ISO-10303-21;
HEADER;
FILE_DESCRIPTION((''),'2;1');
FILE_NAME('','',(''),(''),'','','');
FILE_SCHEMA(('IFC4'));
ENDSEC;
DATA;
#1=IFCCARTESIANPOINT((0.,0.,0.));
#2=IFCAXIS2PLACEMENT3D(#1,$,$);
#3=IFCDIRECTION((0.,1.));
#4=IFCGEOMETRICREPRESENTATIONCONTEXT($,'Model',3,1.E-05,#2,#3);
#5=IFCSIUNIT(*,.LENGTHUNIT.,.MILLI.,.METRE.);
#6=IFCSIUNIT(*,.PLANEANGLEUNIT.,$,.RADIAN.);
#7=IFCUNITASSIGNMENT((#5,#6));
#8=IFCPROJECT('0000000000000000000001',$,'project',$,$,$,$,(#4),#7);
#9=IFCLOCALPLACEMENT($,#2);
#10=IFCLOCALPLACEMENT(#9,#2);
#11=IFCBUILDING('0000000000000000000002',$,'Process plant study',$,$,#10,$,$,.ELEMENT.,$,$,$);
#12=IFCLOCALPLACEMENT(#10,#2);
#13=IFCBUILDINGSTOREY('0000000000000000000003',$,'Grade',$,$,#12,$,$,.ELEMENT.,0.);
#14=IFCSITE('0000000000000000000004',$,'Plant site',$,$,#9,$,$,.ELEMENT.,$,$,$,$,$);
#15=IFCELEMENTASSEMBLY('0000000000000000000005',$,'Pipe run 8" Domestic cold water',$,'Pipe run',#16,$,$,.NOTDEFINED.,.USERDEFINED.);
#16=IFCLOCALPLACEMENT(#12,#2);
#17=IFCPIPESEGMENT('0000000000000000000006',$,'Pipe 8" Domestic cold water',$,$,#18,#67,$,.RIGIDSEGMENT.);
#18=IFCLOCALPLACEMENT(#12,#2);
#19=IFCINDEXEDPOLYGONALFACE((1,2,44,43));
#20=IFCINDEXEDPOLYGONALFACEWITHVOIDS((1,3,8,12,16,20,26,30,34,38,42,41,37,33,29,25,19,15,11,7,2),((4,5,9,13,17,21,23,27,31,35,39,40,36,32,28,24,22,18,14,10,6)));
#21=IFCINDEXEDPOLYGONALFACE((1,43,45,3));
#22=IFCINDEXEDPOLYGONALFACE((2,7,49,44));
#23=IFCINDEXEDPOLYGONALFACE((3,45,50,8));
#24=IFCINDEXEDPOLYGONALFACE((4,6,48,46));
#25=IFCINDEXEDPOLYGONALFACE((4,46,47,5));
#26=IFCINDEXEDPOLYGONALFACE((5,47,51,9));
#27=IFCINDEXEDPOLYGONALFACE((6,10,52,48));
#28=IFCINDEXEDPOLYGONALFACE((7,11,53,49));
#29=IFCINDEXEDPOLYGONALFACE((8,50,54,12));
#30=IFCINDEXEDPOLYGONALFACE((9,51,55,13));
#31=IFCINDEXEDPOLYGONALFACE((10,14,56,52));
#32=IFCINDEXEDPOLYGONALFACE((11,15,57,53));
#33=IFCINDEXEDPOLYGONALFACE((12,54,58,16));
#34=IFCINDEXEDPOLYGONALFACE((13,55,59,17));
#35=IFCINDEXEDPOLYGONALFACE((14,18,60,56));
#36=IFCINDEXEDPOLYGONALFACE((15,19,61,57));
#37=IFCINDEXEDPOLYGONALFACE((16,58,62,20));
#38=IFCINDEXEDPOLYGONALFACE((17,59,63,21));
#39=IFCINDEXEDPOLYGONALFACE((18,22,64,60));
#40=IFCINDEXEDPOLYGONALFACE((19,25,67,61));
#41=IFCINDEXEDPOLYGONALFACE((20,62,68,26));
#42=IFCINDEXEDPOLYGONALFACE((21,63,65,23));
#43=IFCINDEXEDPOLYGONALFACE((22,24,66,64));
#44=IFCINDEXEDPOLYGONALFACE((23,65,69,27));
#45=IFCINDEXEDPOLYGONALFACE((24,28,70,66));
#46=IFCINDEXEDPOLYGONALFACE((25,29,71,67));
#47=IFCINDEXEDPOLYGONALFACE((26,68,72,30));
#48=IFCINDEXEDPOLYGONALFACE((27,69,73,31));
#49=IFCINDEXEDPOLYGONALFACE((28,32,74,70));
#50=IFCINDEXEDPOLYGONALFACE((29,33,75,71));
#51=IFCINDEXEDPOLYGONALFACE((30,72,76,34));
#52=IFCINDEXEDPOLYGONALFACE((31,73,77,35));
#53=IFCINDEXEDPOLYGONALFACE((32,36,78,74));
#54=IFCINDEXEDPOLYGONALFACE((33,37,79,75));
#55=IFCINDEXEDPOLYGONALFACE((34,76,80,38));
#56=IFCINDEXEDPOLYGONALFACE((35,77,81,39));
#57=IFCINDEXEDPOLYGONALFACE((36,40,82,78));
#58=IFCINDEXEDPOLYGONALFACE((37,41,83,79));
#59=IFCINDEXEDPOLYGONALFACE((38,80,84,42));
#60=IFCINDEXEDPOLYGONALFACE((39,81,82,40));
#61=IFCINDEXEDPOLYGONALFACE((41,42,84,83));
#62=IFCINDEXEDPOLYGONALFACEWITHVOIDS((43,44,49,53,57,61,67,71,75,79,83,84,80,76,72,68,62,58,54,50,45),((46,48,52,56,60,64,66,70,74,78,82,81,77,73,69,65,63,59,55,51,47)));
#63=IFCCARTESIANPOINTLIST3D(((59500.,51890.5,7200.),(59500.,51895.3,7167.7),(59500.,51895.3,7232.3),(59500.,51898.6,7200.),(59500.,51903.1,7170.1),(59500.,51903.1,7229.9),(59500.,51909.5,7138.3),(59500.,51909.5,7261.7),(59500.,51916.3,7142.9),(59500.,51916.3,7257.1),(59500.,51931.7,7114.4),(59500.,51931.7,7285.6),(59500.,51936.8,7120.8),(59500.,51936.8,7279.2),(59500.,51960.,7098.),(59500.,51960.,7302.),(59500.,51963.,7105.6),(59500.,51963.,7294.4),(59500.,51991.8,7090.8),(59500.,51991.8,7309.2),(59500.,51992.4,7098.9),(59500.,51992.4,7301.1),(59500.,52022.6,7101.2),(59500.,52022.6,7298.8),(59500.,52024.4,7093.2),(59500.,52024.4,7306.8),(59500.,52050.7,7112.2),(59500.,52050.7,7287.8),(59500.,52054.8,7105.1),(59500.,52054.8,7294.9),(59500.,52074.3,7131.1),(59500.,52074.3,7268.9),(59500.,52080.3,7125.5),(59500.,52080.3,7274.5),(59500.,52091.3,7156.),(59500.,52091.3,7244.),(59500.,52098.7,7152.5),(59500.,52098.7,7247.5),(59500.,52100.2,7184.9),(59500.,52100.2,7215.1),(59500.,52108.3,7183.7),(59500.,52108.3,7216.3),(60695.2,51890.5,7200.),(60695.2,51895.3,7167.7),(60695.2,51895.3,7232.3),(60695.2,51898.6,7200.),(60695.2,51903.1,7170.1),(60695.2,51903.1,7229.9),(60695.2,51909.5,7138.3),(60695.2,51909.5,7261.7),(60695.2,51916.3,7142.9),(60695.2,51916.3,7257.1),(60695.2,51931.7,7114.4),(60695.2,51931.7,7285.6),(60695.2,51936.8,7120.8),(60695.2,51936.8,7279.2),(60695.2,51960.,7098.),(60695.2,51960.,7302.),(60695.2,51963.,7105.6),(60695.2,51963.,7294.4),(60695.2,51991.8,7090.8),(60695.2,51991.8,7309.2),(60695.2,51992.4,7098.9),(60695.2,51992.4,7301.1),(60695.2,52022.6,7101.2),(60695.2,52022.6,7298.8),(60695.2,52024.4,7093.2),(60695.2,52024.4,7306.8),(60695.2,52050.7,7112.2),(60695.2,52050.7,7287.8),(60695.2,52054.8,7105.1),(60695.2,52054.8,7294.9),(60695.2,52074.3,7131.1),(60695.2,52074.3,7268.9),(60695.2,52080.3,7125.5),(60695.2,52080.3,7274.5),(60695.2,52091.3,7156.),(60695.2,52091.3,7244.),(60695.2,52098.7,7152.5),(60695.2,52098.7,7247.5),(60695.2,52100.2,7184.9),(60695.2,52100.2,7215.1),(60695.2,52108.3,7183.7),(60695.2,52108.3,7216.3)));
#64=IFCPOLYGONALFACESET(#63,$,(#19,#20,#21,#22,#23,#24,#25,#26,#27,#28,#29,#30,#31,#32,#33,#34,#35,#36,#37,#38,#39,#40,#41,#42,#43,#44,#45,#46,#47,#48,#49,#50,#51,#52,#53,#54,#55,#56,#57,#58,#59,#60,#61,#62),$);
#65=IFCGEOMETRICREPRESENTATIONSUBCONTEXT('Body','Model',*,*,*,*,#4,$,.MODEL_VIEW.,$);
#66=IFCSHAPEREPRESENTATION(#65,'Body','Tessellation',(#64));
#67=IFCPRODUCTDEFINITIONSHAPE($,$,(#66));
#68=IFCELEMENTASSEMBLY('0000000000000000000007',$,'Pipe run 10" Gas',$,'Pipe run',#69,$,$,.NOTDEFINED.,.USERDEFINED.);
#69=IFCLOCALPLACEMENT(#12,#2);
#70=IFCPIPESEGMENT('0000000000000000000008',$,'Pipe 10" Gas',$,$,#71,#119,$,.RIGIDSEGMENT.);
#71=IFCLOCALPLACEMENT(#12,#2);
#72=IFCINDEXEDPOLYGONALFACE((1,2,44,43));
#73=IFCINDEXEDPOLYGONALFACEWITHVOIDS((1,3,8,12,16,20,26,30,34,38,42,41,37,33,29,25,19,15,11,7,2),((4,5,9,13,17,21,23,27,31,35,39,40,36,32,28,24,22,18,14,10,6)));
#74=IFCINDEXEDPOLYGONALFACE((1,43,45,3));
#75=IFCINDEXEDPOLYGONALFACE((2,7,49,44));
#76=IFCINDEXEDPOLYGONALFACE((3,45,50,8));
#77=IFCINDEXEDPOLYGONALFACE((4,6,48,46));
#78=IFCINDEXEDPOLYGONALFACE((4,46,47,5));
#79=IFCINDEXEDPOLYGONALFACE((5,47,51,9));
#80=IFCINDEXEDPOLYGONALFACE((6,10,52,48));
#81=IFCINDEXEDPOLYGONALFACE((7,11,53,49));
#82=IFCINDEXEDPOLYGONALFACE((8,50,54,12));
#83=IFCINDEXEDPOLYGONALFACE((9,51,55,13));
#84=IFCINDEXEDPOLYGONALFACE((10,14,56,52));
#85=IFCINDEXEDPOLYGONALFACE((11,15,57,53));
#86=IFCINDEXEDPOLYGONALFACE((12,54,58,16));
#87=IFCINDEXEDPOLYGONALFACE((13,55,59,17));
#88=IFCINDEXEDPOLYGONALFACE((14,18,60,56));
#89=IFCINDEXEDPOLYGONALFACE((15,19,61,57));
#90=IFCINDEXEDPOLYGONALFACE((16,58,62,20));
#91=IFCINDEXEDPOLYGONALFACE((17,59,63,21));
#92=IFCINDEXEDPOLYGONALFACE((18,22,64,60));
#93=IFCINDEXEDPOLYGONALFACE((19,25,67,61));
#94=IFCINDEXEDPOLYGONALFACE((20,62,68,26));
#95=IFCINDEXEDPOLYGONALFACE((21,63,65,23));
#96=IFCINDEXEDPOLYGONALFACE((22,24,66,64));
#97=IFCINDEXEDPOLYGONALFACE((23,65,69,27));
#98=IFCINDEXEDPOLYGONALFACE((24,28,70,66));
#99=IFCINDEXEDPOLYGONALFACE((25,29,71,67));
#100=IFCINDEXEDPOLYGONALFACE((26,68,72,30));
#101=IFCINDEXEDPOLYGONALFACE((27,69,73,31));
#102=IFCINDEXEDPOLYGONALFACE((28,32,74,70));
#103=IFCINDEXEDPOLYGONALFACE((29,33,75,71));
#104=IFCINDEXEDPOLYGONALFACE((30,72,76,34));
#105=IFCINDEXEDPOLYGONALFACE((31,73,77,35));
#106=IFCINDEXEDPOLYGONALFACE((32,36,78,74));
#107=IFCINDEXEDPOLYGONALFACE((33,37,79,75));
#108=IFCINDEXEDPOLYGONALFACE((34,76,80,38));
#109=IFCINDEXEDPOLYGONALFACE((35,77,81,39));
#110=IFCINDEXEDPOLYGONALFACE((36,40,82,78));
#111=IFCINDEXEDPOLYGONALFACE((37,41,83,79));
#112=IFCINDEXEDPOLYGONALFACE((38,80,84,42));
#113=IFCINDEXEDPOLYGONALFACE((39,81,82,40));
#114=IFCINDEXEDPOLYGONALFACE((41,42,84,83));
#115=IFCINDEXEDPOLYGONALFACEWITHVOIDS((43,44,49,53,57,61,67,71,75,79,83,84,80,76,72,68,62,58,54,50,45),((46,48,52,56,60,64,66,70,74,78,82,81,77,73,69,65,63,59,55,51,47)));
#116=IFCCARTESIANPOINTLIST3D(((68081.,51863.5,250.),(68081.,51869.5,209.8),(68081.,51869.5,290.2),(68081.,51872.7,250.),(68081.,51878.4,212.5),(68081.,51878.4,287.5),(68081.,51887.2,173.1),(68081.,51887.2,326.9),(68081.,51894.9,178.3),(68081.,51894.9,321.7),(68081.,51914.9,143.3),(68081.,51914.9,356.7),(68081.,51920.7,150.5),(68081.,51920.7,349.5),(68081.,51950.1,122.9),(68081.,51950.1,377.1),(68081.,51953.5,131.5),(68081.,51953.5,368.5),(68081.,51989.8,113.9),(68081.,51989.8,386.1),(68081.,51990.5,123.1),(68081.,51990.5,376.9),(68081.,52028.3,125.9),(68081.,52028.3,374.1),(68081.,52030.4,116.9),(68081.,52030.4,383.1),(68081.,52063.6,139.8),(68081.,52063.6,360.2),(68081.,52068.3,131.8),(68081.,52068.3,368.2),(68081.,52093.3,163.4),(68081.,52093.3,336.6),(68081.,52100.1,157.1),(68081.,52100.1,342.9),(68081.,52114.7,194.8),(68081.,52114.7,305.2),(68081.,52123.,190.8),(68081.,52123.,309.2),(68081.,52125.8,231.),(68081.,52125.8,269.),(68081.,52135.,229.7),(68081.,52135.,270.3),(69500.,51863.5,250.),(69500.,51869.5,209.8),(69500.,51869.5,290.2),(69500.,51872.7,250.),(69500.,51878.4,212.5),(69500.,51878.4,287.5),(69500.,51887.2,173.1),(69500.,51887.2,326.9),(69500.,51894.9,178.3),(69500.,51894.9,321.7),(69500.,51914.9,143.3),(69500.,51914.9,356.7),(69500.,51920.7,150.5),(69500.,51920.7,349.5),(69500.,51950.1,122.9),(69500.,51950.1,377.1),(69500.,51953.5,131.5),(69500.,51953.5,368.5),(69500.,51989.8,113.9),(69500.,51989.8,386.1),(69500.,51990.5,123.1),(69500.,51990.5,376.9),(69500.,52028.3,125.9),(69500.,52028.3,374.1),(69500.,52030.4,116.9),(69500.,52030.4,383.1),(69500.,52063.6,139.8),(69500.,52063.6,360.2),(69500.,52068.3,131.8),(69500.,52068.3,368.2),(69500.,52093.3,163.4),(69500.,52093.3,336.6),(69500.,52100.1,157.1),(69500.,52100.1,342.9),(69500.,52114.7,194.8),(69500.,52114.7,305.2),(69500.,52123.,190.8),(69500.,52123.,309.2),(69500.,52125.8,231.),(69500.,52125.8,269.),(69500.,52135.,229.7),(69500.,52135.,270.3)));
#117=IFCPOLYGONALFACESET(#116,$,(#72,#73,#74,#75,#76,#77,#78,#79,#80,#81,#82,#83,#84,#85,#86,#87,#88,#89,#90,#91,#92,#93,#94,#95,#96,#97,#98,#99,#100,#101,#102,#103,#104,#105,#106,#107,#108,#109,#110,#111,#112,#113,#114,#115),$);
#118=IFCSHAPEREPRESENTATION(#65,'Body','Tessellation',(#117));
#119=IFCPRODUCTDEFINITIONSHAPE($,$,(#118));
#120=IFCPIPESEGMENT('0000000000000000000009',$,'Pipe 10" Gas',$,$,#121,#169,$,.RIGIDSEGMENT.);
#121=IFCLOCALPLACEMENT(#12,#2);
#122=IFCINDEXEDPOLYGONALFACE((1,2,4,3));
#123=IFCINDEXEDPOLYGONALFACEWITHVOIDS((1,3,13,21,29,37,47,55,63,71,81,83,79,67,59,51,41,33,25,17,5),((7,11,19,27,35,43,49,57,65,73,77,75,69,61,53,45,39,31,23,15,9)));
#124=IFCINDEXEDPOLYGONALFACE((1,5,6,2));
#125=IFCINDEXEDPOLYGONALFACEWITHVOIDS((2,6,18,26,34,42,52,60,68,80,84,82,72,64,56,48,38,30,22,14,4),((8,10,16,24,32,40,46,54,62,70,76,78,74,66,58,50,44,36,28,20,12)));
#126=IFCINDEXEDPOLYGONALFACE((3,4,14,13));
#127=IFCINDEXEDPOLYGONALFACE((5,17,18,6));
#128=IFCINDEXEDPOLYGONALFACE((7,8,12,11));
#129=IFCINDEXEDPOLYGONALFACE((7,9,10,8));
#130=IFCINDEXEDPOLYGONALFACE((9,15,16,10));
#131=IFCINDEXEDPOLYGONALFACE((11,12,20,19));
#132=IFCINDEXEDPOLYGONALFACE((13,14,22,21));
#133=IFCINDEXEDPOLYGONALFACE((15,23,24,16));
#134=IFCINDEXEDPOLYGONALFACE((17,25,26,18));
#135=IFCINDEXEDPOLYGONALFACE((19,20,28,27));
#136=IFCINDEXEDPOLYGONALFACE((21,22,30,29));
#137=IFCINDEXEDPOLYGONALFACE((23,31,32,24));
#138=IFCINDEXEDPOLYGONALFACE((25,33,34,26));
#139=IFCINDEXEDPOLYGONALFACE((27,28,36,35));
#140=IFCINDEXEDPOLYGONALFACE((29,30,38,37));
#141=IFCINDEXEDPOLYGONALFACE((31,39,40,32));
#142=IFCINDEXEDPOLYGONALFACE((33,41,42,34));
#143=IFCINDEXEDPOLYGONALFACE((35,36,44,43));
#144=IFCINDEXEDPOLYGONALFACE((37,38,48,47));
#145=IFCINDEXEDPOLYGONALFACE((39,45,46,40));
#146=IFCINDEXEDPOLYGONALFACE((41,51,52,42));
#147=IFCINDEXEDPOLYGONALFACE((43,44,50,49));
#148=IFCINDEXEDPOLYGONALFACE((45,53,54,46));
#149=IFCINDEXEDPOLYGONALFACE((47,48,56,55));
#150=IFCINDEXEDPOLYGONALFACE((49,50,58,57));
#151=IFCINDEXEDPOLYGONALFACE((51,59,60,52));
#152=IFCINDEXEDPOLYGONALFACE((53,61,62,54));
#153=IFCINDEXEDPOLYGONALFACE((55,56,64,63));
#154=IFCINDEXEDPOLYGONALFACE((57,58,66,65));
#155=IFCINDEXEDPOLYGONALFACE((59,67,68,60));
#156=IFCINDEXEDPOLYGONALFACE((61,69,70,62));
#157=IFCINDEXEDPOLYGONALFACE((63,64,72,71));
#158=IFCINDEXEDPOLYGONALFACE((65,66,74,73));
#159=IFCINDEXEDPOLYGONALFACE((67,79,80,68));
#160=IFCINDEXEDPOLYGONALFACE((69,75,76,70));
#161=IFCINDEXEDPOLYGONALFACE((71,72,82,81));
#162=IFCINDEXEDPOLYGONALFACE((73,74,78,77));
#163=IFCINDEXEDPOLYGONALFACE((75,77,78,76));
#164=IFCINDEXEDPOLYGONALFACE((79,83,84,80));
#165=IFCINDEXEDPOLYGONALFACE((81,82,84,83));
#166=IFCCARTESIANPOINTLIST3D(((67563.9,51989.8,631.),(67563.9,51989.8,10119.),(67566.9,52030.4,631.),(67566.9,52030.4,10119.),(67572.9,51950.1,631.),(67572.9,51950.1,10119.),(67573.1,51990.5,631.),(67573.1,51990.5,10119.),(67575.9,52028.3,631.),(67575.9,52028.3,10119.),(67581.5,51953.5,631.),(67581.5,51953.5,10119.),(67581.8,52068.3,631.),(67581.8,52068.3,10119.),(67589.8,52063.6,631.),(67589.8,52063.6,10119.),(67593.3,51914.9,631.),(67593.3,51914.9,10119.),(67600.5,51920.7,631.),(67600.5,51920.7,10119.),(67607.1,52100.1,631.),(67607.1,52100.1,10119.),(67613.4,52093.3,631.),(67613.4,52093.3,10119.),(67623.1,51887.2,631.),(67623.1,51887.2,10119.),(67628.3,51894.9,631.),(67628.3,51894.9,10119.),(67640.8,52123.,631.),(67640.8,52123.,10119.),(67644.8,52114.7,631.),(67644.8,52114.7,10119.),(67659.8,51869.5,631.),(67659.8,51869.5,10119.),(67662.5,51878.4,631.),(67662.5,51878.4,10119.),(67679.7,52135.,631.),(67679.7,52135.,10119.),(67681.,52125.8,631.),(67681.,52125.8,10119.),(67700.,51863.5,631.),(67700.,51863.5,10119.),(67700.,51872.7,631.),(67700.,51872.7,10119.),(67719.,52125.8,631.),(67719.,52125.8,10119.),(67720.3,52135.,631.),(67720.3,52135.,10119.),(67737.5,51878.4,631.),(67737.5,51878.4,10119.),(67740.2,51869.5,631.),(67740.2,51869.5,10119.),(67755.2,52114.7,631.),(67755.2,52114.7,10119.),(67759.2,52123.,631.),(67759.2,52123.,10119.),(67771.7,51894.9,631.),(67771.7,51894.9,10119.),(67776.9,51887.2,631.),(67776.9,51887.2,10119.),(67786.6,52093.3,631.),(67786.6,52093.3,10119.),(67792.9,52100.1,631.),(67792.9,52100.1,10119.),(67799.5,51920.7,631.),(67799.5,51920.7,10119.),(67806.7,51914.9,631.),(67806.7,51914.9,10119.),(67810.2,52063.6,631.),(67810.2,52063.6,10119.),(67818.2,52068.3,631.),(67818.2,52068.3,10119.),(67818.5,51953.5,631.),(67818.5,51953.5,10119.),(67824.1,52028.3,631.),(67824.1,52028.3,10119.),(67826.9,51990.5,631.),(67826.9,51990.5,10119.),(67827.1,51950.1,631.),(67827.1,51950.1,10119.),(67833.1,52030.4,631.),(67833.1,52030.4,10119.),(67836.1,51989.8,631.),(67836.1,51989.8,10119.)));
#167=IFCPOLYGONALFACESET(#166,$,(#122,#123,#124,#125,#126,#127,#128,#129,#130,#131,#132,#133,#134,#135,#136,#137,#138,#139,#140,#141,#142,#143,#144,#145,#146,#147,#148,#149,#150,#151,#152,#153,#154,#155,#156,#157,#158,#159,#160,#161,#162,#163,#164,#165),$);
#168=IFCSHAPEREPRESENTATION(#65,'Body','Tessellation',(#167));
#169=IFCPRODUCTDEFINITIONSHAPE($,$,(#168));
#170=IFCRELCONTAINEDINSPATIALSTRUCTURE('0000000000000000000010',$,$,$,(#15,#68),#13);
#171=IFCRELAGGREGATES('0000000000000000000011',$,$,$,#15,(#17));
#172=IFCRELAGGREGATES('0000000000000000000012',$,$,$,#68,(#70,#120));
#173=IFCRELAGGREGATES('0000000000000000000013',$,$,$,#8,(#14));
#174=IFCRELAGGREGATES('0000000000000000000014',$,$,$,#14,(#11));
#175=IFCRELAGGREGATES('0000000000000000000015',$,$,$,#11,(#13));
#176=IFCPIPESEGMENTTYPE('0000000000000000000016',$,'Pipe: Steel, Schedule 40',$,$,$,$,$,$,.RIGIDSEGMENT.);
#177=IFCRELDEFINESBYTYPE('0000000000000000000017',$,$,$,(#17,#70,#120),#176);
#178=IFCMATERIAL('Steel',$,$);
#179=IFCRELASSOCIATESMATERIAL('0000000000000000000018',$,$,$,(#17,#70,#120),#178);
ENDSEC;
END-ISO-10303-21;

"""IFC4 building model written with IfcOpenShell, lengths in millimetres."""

from ifc_helpers import new_model, si_unit, direction, frame, origin, origin_with_axes, origin_2d, place, context, subcontext, project, spatial, hollow_circle, extrude, material, type_object, element, aggregate, save


model = new_model("IFC4")

# Units and contexts
model_context = context("Model", 3, precision=1e-05, world=origin(), true_north=direction((0.0, 1.0)))
body_context = subcontext(model_context, "Body", "Model", "MODEL_VIEW")
ifc_project = project(units=[si_unit("LENGTHUNIT", "METRE", prefix="MILLI"), si_unit("PLANEANGLEUNIT", "RADIAN")], contexts=[model_context])

# Site, building, storey
site_placement = place(None, origin())
site = spatial("IfcSite", under=ifc_project, at=site_placement, Name="Plant site", CompositionType="ELEMENT")
building_placement = place(site_placement, origin())
building = spatial("IfcBuilding", under=site, at=building_placement, Name="Process plant study", CompositionType="ELEMENT")
storey_placement = place(building_placement, origin())
storey = spatial("IfcBuildingStorey", under=building, at=storey_placement, Name="Grade", CompositionType="ELEMENT", Elevation=0.0)

# Element assembly, pipe segment
assembly_1_placement = place(storey_placement, origin_with_axes())
assembly_1 = element("IfcElementAssembly", 1, at=assembly_1_placement, inside=storey, Name="Pipe run 8\" Domestic cold water", ObjectType="Pipe run", AssemblyPlace="NOTDEFINED", PredefinedType="USERDEFINED")
ifc_material = material(Name="Steel")
pipe_segment_type = type_object("IfcPipeSegmentType", Name="Pipe: Steel, Schedule 40", PredefinedType="RIGIDSEGMENT")
pipe_segment_1_placement = place(storey_placement, origin_with_axes())
pipe_segment_1 = element("IfcPipeSegment", 2, at=pipe_segment_1_placement, type_object=pipe_segment_type, material=ifc_material, Name="Pipe 8\" Domestic cold water", PredefinedType="RIGIDSEGMENT", context=body_context, shape_type="SweptSolid", body=[
    extrude(hollow_circle(Radius=109.5, WallThickness=8.2, at=origin_2d()), frame((60695.2, 52000.0, 7200.0), z_axis=(-1.0, 0.0, 0.0), x_axis=(0.0, -1.0, 0.0)), (0.0, 0.0, 1.0), 1195.2),
])

# Element assembly, pipe segments
assembly_2_placement = place(storey_placement, origin_with_axes())
assembly_2 = element("IfcElementAssembly", 3, at=assembly_2_placement, inside=storey, Name="Pipe run 10\" Gas", ObjectType="Pipe run", AssemblyPlace="NOTDEFINED", PredefinedType="USERDEFINED")
pipe_segment_2_placement = place(storey_placement, origin_with_axes())
pipe_segment_2 = element("IfcPipeSegment", 4, at=pipe_segment_2_placement, type_object=pipe_segment_type, material=ifc_material, Name="Pipe 10\" Gas", PredefinedType="RIGIDSEGMENT", context=body_context, shape_type="SweptSolid", body=[
    extrude(hollow_circle(Radius=136.5, WallThickness=9.3, at=origin_2d()), frame((69500.0, 52000.0, 250.0), z_axis=(-1.0, 0.0, 0.0), x_axis=(0.0, -1.0, 0.0)), (0.0, 0.0, 1.0), 1419.0),
])
pipe_segment_3_placement = place(storey_placement, origin_with_axes())
pipe_segment_3 = element("IfcPipeSegment", 5, at=pipe_segment_3_placement, type_object=pipe_segment_type, material=ifc_material, Name="Pipe 10\" Gas", PredefinedType="RIGIDSEGMENT", context=body_context, shape_type="SweptSolid", body=[
    extrude(hollow_circle(Radius=136.5, WallThickness=9.3, at=origin_2d()), frame((67700.0, 52000.0, 631.0), z_axis=(0.0, 0.0, 1.0), x_axis=(0.0, -1.0, 0.0)), (0.0, 0.0, 1.0), 9488.0),
])

aggregate(assembly_1, [pipe_segment_1])
aggregate(assembly_2, [pipe_segment_2, pipe_segment_3])

save(model, "model.ifc")
